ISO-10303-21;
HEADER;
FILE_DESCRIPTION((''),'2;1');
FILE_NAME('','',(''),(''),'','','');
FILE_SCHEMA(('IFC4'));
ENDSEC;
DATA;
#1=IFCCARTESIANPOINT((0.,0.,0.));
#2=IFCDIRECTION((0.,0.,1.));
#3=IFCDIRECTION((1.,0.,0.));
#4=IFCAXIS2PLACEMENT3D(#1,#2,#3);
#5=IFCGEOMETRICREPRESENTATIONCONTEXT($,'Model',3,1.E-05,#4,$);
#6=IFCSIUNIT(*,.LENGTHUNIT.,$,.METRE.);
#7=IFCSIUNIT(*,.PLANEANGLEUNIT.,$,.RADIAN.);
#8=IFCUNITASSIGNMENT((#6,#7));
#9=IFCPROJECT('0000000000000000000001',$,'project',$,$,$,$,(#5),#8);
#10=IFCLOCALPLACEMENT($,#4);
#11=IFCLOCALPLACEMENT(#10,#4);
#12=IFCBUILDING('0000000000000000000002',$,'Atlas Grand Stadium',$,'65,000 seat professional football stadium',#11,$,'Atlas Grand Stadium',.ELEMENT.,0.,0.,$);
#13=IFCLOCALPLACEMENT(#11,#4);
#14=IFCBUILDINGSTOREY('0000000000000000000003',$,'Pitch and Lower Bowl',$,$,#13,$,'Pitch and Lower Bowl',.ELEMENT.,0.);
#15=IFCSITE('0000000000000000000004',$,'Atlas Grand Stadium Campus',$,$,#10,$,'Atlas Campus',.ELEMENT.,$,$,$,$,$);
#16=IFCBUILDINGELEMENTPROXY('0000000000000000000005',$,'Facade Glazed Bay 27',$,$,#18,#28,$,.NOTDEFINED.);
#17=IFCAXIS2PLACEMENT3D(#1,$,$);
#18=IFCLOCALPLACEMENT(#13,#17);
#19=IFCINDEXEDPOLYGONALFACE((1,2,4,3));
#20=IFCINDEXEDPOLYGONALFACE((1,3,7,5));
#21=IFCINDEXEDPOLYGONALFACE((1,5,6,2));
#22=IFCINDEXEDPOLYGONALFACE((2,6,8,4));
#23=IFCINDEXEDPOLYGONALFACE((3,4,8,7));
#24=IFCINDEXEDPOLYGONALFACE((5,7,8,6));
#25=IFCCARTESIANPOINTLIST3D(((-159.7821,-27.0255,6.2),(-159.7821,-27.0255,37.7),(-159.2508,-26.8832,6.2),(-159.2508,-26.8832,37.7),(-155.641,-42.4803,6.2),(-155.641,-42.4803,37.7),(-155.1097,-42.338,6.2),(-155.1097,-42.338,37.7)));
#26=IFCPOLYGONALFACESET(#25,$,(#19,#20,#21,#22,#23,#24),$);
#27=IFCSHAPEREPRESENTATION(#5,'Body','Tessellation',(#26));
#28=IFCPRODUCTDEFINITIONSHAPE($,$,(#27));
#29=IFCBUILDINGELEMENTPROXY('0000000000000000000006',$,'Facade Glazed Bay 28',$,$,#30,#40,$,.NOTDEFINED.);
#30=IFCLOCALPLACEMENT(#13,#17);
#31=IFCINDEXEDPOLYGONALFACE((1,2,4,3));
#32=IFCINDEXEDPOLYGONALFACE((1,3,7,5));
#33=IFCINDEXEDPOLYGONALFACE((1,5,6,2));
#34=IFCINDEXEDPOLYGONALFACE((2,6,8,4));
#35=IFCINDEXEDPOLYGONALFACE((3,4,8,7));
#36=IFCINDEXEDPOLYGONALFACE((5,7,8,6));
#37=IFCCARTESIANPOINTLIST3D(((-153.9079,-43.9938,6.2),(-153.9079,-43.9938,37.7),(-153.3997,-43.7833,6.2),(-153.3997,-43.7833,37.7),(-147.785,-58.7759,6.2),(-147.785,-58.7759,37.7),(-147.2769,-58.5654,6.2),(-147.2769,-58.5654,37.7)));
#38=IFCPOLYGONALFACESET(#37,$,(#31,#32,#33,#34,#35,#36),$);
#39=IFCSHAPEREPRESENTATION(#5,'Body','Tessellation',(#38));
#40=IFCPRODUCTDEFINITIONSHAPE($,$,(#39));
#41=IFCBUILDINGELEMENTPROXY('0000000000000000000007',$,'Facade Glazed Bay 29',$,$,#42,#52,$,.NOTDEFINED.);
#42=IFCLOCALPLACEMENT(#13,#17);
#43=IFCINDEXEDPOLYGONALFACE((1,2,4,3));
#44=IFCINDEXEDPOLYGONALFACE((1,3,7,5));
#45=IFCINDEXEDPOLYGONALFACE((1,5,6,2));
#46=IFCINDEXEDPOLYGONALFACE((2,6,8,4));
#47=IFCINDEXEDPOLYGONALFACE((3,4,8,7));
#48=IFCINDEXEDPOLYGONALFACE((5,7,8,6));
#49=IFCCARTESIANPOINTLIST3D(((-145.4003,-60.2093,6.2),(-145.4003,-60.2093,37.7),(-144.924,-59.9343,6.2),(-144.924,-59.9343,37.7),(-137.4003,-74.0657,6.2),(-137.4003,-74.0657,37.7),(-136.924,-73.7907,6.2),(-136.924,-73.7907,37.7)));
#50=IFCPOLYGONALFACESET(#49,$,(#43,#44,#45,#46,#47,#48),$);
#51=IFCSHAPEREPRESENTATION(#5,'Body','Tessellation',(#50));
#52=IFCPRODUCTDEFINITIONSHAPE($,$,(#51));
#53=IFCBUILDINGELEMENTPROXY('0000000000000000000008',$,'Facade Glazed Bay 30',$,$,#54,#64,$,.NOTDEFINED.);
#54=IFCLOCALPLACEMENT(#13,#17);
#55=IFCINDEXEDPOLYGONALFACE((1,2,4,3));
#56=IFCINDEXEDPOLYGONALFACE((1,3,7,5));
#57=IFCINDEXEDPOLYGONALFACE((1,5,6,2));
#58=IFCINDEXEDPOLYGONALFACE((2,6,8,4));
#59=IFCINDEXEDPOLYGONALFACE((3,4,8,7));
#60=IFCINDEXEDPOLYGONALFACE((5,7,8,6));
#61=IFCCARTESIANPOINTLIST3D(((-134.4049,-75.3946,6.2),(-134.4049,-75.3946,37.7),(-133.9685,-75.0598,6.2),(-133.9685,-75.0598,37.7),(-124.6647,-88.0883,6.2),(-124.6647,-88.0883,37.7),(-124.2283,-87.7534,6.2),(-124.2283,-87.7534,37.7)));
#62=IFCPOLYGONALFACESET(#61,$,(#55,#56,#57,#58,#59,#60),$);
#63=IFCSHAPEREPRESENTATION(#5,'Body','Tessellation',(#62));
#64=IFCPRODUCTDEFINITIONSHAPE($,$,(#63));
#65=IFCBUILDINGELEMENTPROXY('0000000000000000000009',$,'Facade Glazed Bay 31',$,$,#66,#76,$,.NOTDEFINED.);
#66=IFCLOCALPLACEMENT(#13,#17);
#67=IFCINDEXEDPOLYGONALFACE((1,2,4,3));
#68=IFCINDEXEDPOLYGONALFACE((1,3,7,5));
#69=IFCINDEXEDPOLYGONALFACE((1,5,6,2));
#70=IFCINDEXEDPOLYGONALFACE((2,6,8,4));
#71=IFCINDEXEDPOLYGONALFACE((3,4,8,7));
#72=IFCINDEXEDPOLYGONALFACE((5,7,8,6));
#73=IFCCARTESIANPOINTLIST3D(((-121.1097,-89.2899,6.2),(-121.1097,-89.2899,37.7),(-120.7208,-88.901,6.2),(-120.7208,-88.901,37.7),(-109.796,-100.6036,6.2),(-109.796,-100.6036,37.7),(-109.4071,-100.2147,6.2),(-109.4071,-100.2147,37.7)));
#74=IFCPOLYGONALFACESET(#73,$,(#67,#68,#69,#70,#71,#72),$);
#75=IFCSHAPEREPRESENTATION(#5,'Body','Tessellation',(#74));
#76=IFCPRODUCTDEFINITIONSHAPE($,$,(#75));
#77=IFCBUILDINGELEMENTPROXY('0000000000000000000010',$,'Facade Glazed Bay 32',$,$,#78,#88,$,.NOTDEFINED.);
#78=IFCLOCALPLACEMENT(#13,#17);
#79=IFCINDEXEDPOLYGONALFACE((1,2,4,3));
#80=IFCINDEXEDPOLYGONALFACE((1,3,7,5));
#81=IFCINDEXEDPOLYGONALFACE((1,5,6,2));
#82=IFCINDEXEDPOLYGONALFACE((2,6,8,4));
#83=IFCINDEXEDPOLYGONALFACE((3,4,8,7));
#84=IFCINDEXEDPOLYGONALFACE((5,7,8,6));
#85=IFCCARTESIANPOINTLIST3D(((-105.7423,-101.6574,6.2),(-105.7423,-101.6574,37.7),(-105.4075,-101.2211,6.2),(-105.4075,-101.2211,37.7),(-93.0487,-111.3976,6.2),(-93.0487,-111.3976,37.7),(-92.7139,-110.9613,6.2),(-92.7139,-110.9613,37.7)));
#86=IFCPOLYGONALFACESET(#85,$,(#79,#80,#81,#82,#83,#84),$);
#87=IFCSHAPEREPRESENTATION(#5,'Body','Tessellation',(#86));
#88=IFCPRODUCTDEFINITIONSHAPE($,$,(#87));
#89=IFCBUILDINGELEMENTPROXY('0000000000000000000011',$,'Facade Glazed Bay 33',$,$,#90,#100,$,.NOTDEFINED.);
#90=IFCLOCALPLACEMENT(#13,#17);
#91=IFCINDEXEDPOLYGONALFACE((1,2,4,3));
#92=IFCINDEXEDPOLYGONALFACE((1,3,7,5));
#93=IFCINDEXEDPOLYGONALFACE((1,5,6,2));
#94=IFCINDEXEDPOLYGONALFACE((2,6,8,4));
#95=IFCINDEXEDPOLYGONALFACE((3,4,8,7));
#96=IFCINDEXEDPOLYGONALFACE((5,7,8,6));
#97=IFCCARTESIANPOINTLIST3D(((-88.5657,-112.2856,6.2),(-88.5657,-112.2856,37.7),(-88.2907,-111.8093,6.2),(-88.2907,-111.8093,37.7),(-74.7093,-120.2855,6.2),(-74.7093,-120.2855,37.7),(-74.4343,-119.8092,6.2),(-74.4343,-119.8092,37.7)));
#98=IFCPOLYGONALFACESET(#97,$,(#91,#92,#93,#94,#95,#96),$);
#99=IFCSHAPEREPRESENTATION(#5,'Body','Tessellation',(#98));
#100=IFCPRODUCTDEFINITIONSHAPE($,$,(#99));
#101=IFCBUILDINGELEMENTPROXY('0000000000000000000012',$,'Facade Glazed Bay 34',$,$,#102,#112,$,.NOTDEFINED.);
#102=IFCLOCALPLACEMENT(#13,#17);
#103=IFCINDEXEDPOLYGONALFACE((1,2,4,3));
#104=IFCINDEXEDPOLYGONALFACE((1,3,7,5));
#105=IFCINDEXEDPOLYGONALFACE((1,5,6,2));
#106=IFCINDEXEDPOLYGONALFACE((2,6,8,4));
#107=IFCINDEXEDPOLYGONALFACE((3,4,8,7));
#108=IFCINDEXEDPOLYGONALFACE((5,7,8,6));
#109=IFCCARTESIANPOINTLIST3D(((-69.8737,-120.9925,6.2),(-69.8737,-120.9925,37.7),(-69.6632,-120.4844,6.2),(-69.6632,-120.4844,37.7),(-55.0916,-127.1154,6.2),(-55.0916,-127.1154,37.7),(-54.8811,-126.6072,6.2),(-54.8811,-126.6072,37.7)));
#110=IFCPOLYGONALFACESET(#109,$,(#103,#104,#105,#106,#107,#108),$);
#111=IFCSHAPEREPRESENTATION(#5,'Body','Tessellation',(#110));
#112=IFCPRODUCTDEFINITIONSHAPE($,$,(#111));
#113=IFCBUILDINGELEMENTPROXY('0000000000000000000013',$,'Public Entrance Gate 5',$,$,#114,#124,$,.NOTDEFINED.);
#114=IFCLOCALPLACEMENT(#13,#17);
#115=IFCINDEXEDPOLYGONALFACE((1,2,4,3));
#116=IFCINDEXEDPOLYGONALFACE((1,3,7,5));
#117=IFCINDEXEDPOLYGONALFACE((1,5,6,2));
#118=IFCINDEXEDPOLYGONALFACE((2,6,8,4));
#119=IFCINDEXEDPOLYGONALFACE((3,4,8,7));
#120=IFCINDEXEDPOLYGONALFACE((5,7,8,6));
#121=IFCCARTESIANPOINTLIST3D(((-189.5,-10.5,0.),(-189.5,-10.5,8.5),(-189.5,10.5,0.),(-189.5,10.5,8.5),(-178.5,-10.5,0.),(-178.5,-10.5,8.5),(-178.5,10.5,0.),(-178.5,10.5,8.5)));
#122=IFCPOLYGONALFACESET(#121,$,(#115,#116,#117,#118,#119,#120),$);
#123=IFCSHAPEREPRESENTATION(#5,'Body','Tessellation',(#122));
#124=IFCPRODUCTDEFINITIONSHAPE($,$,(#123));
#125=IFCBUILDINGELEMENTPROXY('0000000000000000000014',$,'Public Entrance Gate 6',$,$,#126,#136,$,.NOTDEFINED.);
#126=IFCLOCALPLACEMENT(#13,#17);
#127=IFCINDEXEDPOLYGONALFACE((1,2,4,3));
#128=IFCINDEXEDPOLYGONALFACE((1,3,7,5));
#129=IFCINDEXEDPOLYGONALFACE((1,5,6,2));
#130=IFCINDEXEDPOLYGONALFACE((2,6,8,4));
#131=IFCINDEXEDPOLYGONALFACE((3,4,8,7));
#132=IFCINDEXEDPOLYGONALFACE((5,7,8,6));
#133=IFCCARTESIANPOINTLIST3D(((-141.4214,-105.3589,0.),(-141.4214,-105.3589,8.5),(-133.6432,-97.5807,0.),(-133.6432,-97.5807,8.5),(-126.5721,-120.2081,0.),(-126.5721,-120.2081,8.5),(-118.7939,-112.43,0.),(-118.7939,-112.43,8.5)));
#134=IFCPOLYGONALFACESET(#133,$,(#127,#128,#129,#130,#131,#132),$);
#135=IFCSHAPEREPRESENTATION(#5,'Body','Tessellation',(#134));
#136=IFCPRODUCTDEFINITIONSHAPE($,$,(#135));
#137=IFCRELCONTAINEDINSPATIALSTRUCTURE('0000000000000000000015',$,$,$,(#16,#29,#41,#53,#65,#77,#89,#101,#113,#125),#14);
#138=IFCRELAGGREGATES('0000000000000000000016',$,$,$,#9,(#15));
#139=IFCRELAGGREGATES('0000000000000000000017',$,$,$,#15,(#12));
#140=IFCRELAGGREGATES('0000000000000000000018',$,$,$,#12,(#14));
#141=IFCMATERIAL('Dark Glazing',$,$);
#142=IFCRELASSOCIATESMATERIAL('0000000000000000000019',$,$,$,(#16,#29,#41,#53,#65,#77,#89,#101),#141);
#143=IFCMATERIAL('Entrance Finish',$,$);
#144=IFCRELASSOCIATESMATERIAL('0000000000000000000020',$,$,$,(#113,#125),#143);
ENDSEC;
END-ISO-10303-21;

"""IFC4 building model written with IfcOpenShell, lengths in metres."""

from ifc_helpers import new_model, si_unit, frame, origin_with_axes, origin_2d_with_axis, place, context, project, spatial, rectangle, extrude, material, element, save


model = new_model("IFC4")

# Units and contexts
model_context = context("Model", 3, precision=1e-05, world=origin_with_axes())
ifc_project = project(units=[si_unit("LENGTHUNIT", "METRE"), si_unit("PLANEANGLEUNIT", "RADIAN")], contexts=[model_context])

# Site, building, storey
site_placement = place(None, origin_with_axes())
site = spatial("IfcSite", under=ifc_project, at=site_placement, Name="Atlas Grand Stadium Campus", LongName="Atlas Campus", CompositionType="ELEMENT")
building_placement = place(site_placement, origin_with_axes())
building = spatial("IfcBuilding", under=site, at=building_placement, Name="Atlas Grand Stadium", ObjectType="65,000 seat professional football stadium", LongName="Atlas Grand Stadium", CompositionType="ELEMENT", ElevationOfRefHeight=0.0, ElevationOfTerrain=0.0)
storey_placement = place(building_placement, origin_with_axes())
storey = spatial("IfcBuildingStorey", under=building, at=storey_placement, Name="Pitch and Lower Bowl", LongName="Pitch and Lower Bowl", CompositionType="ELEMENT", Elevation=0.0)

# Building element proxies
ifc_material_1 = material(Name="Dark Glazing")
for number, where, z_axis, x_axis, name in (
    (1, (-157.4459, -34.6818, 6.2), (0.0, 0.0, 1.0), (0.25882, -0.96593, 0.0), "Facade Glazed Bay 27"),
    (2, (-150.5924, -51.2796, 6.2), (0.0, 0.0, 1.0), (0.38268, -0.92388, 0.0), "Facade Glazed Bay 28"),
    (3, (-141.1621, -67.0, 6.2), (0.0, 0.0, 1.0), (0.5, -0.86603, 0.0), "Facade Glazed Bay 29"),
    (4, (-129.3166, -81.574, 6.2), (0.0, 0.0, 1.0), (0.60876, -0.79335, 0.0), "Facade Glazed Bay 30"),
    (5, (-115.2584, -94.7523, 6.2), (0.0, 0.0, 1.0), (0.70711, -0.70711, 0.0), "Facade Glazed Bay 31"),
    (6, (-99.2281, -106.3093, 6.2), (0.0, 0.0, 1.0), (0.79335, -0.60876, 0.0), "Facade Glazed Bay 32"),
    (7, (-81.5, -116.0474, 6.2), (0.0, 0.0, 1.0), (0.86603, -0.5, 0.0), "Facade Glazed Bay 33"),
    (8, (-62.3774, -123.7999, 6.2), (0.0, 0.0, 1.0), (0.92388, -0.38268, 0.0), "Facade Glazed Bay 34"),
):
    element("IfcBuildingElementProxy", number, at=place(storey_placement, frame(where, z_axis=z_axis, x_axis=x_axis)), inside=storey, material=ifc_material_1, Name=name, PredefinedType="NOTDEFINED", context=model_context, shape_type="SweptSolid", body=[
        extrude(rectangle(XDim=16.0, YDim=0.55, at=origin_2d_with_axis()), origin_with_axes(), (0.0, 0.0, 1.0), 31.5),
    ])
ifc_material_2 = material(Name="Entrance Finish")
for number, where, z_axis, x_axis, name in (
    (9, (-184.0, 0.0, 0.0), (0.0, 0.0, 1.0), (0.0, -1.0, 0.0), "Public Entrance Gate 5"),
    (10, (-130.1077, -108.8944, 0.0), (0.0, 0.0, 1.0), (0.70711, -0.70711, 0.0), "Public Entrance Gate 6"),
):
    element("IfcBuildingElementProxy", number, at=place(storey_placement, frame(where, z_axis=z_axis, x_axis=x_axis)), inside=storey, material=ifc_material_2, Name=name, PredefinedType="NOTDEFINED", context=model_context, shape_type="SweptSolid", body=[
        extrude(rectangle(XDim=21.0, YDim=11.0, at=origin_2d_with_axis()), origin_with_axes(), (0.0, 0.0, 1.0), 8.5),
    ])

save(model, "model.ifc")
